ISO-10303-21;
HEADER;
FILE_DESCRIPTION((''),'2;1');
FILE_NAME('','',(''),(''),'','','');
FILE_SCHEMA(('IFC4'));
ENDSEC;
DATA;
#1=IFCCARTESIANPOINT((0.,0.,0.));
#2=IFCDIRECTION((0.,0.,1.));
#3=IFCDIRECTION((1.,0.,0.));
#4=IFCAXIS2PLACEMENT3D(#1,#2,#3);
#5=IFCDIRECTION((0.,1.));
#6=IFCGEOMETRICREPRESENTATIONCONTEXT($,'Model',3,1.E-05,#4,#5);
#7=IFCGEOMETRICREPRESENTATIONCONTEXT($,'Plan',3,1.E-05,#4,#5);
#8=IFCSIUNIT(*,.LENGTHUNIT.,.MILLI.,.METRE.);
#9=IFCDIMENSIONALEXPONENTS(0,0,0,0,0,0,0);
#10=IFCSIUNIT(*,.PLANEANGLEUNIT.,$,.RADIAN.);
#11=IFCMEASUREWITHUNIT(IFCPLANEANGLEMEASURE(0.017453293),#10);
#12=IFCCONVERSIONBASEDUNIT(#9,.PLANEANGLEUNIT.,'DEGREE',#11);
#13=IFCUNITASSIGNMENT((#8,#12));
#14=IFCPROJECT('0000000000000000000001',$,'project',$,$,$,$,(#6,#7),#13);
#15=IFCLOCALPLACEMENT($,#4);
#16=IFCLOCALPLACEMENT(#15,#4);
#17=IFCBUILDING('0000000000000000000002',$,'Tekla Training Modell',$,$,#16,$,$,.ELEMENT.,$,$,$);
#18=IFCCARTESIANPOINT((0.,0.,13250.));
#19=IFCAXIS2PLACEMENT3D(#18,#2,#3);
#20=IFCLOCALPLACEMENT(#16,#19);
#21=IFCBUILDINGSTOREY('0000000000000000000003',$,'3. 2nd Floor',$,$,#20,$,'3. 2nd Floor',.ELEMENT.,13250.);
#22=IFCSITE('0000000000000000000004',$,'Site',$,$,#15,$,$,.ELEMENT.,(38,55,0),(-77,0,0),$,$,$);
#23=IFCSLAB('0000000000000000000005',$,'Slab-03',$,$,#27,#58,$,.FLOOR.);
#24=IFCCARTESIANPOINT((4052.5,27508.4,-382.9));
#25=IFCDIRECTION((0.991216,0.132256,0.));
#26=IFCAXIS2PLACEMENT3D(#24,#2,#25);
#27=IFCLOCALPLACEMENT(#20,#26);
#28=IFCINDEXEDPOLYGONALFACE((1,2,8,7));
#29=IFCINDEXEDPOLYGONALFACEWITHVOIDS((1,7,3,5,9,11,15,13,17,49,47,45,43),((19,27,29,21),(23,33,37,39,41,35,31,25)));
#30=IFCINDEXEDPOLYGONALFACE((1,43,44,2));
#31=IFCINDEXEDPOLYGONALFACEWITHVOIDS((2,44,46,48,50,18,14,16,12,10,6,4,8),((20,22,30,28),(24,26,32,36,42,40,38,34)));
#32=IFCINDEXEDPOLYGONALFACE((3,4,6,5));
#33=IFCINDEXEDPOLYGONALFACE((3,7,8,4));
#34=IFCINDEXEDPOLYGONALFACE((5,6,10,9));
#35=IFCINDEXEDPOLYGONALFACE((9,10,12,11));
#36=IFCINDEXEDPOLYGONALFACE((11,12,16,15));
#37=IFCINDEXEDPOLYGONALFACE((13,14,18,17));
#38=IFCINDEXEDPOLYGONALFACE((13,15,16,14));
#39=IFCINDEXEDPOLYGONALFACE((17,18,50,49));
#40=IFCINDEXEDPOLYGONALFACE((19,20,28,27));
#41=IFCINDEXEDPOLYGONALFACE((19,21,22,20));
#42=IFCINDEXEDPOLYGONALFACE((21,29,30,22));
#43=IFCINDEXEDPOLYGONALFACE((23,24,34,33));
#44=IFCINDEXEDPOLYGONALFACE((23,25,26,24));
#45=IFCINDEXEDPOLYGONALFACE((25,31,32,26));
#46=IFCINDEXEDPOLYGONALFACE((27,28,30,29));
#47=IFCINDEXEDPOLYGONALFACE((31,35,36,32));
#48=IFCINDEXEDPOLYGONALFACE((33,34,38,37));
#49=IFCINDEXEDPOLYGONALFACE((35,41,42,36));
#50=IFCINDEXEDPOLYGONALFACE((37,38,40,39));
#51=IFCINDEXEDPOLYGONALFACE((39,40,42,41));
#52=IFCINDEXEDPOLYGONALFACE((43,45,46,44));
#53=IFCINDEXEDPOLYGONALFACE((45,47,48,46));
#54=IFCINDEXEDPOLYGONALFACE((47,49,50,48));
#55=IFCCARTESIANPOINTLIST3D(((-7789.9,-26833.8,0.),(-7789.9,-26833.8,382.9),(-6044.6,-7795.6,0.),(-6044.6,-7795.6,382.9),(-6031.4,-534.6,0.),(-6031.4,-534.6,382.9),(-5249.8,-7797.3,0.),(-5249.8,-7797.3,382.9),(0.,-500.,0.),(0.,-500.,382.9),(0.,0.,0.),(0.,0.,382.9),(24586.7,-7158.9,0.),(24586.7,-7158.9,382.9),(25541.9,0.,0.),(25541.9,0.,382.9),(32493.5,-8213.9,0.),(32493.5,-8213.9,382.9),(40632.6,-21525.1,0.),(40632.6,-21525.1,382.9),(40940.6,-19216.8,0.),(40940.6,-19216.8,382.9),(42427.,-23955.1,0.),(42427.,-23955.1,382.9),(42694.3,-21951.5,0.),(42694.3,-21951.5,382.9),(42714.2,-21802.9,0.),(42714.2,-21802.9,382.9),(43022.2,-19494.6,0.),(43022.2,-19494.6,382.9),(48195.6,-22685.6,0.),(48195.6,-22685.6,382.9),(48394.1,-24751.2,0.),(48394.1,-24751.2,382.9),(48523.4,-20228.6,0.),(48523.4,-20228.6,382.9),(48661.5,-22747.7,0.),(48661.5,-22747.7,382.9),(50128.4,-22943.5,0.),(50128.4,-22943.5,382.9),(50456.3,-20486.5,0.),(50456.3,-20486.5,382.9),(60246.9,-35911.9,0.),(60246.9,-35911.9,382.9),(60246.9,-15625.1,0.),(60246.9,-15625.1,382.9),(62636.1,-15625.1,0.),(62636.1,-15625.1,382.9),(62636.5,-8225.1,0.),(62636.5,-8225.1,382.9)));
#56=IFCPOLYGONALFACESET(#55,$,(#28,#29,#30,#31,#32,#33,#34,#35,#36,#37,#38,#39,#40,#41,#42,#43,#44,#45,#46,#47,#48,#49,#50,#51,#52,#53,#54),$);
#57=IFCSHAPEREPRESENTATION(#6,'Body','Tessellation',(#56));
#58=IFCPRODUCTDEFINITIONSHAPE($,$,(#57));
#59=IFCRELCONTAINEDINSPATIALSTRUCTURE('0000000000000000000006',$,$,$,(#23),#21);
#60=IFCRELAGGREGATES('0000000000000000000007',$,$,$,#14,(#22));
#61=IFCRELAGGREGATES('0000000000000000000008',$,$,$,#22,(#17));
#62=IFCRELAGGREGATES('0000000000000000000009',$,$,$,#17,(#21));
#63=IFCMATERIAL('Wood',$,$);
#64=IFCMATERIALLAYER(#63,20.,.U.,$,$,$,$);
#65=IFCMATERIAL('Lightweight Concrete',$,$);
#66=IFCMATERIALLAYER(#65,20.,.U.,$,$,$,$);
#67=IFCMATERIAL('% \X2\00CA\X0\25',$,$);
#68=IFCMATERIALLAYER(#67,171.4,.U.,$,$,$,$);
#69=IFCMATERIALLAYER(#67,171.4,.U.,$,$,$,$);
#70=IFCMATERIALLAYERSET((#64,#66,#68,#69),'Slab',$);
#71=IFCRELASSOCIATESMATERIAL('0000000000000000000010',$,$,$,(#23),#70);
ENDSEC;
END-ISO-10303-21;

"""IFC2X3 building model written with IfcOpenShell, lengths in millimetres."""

from ifc_helpers import new_model, entity, si_unit, converted_unit, direction, frame, origin_with_axes, place, context, project, spatial, polyline, outline, extrude, material, layer, layer_set, layer_usage, element, save


model = new_model("IFC2X3")

# Units and contexts
model_context = context("Model", 3, precision=1e-05, world=origin_with_axes(), true_north=direction((0.0, 1.0)))
plan_context = context("Plan", 3, precision=1e-05, world=origin_with_axes(), true_north=direction((0.0, 1.0)))
ifc_project = project(units=[si_unit("LENGTHUNIT", "METRE", prefix="MILLI"), converted_unit("PLANEANGLEUNIT", "DEGREE", entity("IfcPlaneAngleMeasure", 0.017453293), si_unit("PLANEANGLEUNIT", "RADIAN"), dimensions=[0, 0, 0, 0, 0, 0, 0])], contexts=[model_context, plan_context])

# Site, building, storey
site_placement = place(None, origin_with_axes())
site = spatial("IfcSite", under=ifc_project, at=site_placement, Name="Site", CompositionType="ELEMENT", RefLatitude=(38, 55, 0), RefLongitude=(-77, 0, 0))
building_placement = place(site_placement, origin_with_axes())
building = spatial("IfcBuilding", under=site, at=building_placement, Name="Tekla Training Modell", CompositionType="ELEMENT")
storey_placement = place(building_placement, frame((0.0, 0.0, 13250.0), z_axis=(0.0, 0.0, 1.0), x_axis=(1.0, 0.0, 0.0)))
storey = spatial("IfcBuildingStorey", under=building, at=storey_placement, Name="3. 2nd Floor", LongName="3. 2nd Floor", CompositionType="ELEMENT", Elevation=13250.0)

# Slab, openings
ifc_material_1 = material(Name="Wood")
ifc_layer_1 = layer(ifc_material_1, 20.0, ventilated="UNKNOWN")
ifc_material_2 = material(Name="Lightweight Concrete")
ifc_layer_2 = layer(ifc_material_2, 20.0, ventilated="UNKNOWN")
ifc_material_3 = material(Name="% Ê25")
ifc_layer_3 = layer(ifc_material_3, 171.4, ventilated="UNKNOWN")
ifc_layer_4 = layer(ifc_material_3, 171.4, ventilated="UNKNOWN")
ifc_layer_set_1 = layer_set([ifc_layer_1, ifc_layer_2, ifc_layer_3, ifc_layer_4], Name="Slab")
ifc_layer_usage_1 = layer_usage(ifc_layer_set_1, "AXIS3", "NEGATIVE", 382.9)
slab_placement = place(storey_placement, frame((4052.5, 27508.4, -382.9), z_axis=(0.0, 0.0, 1.0), x_axis=(0.991216, 0.132256, 0.0)))
slab = element("IfcSlab", 1, at=slab_placement, inside=storey, material=ifc_layer_usage_1, Name="Slab-03", PredefinedType="FLOOR", context=model_context, shape_type="SweptSolid", body=[
    extrude(outline(polyline([(0.0, 0.0), (25541.9, 0.0), (24586.7, -7158.9), (32493.5, -8213.9), (62636.5, -8225.1), (62636.1, -15625.1), (60246.9, -15625.1), (60246.9, -35911.9), (-7789.9, -26833.8), (-5249.8, -7797.3), (-6044.6, -7795.6), (-6031.4, -534.6), (0.0, -500.0), (0.0, 0.0)])), origin_with_axes(), (0.0, 0.0, 1.0), 382.9),
])
opening_1_placement = place(slab_placement, origin_with_axes())
element("IfcOpeningElement", 2, at=opening_1_placement, cuts=slab, context=model_context, shape_type="SweptSolid", body=[
    extrude(outline(polyline([(43022.2, -19494.6), (42714.2, -21802.9), (40632.6, -21525.1), (40940.6, -19216.8), (43022.2, -19494.6)])), origin_with_axes(), (0.0, 0.0, 1.0), 382.9),
])
opening_2_placement = place(slab_placement, origin_with_axes())
element("IfcOpeningElement", 3, at=opening_2_placement, cuts=slab, context=model_context, shape_type="SweptSolid", body=[
    extrude(outline(polyline([(50128.4, -22943.5), (48661.4, -22747.7), (48394.1, -24751.2), (42427.0, -23955.1), (42694.3, -21951.5), (48195.6, -22685.6), (48523.4, -20228.6), (50456.3, -20486.5), (50128.4, -22943.5)])), origin_with_axes(), (0.0, 0.0, 1.0), 382.9),
])

save(model, "model.ifc")
